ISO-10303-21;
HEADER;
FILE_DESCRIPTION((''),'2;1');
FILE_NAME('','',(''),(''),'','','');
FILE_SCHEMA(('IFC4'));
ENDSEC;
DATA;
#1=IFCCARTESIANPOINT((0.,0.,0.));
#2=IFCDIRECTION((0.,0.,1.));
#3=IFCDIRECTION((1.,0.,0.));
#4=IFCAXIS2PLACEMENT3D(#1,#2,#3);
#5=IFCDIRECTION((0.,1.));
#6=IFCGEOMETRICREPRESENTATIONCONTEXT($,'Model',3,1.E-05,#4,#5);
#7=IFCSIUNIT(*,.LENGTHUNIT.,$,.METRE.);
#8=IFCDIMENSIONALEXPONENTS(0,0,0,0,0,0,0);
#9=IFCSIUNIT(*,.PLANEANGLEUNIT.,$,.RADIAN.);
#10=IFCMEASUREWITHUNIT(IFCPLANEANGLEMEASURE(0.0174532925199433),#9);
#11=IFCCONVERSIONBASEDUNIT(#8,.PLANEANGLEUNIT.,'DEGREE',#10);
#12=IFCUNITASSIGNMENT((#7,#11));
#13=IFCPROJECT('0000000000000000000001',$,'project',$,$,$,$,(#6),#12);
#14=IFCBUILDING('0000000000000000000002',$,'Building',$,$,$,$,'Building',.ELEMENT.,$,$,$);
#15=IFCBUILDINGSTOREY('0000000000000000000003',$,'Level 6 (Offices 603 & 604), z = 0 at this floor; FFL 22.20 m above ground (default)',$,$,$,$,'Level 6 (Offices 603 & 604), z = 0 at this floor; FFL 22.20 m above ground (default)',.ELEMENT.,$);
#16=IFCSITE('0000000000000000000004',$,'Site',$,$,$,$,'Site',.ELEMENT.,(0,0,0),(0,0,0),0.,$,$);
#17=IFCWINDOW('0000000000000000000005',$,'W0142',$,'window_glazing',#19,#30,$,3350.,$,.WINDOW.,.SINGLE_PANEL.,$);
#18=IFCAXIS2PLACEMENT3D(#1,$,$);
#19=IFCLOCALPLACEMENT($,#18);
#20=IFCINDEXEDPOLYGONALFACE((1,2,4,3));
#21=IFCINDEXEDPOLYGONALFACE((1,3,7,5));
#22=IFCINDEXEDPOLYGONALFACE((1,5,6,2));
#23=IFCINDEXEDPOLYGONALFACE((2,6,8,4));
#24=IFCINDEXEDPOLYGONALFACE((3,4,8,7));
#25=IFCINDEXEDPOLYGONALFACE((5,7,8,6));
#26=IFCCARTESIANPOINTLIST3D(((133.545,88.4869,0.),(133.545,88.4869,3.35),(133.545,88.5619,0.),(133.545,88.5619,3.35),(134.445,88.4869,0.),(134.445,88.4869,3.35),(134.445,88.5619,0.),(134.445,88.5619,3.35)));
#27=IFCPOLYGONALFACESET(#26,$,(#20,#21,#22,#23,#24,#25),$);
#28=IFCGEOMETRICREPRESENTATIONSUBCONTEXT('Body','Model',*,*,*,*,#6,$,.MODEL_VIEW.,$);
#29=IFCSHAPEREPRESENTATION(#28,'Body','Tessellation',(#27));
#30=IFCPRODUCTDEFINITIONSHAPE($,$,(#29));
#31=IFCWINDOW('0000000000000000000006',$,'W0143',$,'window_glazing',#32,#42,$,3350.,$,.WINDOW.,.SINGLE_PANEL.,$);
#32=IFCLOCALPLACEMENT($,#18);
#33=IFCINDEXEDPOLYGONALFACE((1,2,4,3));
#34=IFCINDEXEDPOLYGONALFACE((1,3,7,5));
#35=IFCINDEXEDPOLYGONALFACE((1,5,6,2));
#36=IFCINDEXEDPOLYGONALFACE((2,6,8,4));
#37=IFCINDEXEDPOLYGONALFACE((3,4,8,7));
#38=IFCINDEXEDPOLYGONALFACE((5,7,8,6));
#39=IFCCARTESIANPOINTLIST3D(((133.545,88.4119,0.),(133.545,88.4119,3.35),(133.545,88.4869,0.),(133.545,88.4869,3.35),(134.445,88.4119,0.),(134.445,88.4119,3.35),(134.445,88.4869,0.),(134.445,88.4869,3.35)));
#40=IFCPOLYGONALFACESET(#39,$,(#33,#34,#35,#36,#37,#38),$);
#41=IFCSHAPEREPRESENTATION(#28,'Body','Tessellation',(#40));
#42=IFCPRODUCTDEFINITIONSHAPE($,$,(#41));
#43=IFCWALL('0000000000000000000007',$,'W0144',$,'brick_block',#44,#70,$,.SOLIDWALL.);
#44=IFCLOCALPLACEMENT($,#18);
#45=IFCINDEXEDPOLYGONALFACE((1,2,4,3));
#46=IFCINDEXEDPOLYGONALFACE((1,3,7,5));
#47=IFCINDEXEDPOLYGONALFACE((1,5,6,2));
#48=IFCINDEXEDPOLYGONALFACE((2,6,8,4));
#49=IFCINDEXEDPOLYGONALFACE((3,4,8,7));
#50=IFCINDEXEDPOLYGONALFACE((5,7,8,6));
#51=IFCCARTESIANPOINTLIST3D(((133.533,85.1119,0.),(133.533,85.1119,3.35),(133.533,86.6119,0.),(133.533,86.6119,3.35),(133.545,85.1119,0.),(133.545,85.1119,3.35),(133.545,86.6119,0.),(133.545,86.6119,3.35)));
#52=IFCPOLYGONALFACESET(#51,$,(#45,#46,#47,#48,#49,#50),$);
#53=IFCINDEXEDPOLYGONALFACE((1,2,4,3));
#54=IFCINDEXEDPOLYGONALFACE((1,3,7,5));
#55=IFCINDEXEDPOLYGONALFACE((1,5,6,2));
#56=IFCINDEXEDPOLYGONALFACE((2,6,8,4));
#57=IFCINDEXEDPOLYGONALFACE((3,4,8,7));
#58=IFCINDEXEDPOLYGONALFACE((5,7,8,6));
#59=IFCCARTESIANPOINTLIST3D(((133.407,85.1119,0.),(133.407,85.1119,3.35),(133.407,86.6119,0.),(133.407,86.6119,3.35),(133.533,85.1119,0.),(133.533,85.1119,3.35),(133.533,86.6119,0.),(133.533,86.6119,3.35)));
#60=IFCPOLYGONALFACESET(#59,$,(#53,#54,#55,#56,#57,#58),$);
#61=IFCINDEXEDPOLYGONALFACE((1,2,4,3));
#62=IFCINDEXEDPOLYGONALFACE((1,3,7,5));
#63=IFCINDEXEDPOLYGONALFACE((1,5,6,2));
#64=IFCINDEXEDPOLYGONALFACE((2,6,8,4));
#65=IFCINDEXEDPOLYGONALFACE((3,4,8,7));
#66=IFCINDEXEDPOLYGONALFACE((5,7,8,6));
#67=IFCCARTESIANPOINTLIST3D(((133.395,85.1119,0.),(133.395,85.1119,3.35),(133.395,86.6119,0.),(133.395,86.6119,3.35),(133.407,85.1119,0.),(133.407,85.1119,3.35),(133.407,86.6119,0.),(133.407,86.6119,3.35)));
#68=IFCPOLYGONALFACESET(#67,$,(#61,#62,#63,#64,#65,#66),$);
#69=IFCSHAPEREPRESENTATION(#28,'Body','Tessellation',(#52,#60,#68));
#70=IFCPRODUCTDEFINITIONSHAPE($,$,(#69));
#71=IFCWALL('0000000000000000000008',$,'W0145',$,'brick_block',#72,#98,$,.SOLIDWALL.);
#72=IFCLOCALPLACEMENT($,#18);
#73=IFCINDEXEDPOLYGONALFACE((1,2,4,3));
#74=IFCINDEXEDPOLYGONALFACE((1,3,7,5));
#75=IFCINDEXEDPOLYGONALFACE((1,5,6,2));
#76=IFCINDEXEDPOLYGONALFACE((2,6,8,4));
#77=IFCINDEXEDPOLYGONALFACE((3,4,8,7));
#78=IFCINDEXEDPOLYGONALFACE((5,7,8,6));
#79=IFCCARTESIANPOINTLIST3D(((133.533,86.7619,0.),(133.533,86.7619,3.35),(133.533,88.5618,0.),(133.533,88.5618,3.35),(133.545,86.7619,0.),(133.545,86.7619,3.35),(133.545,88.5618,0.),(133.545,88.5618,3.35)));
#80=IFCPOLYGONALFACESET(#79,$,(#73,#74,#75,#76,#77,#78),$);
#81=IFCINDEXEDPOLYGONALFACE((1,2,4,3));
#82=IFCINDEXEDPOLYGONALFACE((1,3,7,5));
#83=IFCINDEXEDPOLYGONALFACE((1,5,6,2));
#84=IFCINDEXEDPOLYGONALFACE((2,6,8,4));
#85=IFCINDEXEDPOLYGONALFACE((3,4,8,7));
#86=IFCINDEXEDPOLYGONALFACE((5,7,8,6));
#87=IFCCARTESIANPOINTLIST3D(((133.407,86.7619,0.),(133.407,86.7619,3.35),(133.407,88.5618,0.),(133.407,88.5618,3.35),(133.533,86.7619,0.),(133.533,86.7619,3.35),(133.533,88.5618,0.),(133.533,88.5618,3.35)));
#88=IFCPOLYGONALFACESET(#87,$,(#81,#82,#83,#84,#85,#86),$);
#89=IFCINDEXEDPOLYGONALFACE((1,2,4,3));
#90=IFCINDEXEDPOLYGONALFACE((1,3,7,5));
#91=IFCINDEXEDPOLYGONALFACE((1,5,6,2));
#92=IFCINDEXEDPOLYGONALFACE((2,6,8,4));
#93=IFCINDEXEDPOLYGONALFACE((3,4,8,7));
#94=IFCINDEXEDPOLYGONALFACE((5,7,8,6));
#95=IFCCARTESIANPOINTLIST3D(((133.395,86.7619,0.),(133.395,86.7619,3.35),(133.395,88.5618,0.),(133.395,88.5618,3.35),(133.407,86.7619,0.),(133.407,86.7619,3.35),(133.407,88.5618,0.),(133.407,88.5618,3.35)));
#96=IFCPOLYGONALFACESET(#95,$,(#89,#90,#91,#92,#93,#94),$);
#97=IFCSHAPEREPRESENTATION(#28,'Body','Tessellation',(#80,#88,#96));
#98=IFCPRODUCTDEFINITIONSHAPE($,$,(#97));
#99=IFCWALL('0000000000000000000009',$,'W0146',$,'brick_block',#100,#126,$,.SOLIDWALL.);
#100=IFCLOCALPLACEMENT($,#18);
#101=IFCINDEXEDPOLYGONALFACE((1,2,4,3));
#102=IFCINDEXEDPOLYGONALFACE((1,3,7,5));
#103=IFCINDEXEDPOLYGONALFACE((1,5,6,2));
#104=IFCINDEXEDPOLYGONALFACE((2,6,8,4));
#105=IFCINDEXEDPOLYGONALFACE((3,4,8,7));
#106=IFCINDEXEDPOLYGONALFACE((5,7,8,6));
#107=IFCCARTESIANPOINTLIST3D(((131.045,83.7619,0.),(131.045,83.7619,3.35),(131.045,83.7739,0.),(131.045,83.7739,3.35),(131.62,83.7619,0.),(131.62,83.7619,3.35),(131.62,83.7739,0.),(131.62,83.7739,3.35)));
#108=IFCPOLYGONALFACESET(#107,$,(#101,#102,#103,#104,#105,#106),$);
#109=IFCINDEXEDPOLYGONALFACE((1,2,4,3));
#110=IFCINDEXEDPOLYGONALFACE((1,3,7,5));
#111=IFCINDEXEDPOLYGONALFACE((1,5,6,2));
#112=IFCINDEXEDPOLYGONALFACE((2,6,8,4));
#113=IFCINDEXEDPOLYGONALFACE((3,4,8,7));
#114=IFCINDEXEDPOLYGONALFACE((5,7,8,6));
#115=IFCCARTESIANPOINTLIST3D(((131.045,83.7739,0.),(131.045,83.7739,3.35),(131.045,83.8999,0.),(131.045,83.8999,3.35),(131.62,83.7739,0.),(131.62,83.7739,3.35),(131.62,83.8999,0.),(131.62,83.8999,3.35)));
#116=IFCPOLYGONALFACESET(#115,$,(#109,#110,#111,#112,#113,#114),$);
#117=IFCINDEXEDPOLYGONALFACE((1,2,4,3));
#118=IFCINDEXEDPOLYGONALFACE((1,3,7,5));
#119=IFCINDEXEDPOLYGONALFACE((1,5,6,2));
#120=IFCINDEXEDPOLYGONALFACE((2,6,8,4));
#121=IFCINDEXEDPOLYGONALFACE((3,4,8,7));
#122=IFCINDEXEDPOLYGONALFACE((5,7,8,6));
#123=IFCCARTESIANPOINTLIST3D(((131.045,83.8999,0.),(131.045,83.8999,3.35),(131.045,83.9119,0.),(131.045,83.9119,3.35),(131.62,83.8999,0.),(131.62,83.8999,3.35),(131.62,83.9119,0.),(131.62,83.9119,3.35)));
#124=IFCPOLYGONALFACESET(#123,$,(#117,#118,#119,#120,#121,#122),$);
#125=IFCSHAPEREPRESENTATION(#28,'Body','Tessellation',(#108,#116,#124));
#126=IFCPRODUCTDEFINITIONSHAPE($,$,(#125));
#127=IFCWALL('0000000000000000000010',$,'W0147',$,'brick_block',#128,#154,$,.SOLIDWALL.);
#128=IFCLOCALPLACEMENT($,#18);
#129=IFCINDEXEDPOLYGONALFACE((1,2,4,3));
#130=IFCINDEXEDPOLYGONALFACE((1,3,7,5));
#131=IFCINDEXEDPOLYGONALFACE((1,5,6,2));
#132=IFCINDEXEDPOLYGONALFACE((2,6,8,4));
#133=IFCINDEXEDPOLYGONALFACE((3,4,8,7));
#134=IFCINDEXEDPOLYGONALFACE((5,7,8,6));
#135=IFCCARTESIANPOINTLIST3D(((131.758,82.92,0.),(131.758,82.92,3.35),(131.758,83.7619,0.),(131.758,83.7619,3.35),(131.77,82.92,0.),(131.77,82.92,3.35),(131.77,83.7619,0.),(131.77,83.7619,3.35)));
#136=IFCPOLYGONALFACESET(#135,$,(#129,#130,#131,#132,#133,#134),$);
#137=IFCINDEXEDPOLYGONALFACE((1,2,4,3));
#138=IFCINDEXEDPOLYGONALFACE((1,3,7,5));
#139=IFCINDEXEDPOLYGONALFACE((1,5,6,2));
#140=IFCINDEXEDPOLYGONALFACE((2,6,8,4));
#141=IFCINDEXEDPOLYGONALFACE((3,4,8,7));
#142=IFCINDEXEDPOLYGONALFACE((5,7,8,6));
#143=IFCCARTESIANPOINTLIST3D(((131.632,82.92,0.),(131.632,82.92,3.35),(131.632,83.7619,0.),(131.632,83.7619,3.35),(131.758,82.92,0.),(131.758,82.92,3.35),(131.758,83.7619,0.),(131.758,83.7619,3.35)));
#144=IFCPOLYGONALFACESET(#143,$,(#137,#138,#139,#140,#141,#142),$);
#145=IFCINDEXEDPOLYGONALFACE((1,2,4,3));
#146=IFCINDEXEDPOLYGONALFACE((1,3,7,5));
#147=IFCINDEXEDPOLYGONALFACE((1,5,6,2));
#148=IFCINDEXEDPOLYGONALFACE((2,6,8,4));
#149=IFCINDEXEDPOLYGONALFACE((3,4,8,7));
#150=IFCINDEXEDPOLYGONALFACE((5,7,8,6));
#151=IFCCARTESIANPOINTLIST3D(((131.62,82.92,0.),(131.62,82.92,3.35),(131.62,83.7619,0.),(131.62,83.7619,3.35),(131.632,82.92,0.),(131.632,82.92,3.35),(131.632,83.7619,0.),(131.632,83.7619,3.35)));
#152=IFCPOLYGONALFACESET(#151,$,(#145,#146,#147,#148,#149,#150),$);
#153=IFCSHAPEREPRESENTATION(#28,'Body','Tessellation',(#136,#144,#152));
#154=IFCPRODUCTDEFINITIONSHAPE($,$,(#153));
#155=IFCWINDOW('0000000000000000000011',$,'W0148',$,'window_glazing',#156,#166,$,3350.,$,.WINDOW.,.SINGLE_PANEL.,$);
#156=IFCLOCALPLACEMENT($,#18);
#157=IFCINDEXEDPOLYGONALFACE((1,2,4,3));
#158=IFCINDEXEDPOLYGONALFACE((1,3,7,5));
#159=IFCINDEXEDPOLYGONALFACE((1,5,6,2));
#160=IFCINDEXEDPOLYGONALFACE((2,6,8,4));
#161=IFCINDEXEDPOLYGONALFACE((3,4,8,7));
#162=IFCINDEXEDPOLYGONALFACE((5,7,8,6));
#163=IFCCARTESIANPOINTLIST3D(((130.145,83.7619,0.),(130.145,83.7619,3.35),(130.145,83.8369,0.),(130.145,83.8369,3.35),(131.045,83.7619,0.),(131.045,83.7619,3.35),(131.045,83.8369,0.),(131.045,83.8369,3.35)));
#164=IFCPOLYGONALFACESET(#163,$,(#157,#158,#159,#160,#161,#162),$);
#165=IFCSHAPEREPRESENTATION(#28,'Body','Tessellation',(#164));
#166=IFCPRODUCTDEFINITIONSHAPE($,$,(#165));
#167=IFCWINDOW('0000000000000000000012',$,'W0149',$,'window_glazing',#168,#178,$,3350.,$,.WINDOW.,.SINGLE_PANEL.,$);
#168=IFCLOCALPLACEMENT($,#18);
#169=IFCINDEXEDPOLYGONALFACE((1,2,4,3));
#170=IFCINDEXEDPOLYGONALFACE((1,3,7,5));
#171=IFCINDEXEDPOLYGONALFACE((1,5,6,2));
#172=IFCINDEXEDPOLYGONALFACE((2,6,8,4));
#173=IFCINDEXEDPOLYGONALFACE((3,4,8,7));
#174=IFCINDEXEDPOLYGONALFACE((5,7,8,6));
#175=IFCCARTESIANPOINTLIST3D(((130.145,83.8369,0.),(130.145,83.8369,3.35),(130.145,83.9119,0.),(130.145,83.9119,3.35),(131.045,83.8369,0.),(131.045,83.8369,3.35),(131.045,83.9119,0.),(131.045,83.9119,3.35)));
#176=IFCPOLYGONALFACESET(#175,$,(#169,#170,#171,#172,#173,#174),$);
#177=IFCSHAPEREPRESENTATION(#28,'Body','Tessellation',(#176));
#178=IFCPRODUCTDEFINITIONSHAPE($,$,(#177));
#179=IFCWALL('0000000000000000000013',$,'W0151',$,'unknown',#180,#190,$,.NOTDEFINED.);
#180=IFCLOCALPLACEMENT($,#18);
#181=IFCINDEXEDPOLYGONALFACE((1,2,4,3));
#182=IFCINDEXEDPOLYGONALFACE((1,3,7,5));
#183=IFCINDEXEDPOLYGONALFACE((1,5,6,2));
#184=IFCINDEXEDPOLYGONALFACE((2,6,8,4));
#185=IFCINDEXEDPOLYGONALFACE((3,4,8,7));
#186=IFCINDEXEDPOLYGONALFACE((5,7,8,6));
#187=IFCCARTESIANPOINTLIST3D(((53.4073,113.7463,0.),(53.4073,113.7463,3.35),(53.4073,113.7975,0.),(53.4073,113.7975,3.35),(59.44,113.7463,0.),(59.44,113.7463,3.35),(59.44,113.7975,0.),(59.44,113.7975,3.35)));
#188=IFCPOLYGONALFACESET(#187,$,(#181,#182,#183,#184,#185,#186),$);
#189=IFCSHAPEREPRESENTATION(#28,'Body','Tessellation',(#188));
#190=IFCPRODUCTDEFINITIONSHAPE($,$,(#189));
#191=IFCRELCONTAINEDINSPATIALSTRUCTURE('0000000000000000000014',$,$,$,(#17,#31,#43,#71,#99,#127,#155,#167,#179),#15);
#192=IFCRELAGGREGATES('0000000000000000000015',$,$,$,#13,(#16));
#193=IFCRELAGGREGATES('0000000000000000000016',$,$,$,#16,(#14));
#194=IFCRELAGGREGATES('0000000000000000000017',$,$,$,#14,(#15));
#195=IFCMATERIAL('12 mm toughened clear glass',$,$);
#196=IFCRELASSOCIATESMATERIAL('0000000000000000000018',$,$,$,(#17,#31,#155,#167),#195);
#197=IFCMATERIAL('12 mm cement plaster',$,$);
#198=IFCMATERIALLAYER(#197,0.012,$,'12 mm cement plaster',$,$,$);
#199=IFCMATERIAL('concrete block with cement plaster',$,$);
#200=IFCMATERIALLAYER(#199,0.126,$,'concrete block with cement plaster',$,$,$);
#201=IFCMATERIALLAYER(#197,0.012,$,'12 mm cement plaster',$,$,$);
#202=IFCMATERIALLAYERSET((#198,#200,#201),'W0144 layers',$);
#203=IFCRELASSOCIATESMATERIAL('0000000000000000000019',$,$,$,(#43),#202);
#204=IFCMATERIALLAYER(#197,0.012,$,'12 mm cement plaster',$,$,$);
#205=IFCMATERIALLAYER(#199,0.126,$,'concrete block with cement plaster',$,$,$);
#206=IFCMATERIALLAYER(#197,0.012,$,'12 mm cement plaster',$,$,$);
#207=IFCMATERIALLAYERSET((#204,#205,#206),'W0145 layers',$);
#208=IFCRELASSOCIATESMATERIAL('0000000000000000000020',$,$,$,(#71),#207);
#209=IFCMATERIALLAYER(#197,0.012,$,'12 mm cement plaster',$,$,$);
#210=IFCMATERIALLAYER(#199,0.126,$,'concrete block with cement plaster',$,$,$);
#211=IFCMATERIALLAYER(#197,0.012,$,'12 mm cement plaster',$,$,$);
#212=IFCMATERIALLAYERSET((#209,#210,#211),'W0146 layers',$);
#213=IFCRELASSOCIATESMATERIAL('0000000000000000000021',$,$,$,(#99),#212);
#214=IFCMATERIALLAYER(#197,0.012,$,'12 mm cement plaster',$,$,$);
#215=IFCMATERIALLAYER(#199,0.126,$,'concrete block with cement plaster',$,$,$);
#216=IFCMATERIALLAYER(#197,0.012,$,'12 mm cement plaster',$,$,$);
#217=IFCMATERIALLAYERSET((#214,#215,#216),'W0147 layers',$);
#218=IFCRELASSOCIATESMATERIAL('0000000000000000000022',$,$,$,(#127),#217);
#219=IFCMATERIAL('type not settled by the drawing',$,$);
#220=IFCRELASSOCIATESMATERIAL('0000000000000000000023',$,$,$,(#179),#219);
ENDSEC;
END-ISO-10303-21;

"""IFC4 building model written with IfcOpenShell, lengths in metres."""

from ifc_helpers import new_model, entity, si_unit, converted_unit, direction, frame, frame_2d, origin_with_axes, origin_2d_with_axis, place, context, subcontext, project, spatial, rectangle, extrude, material, layer, layer_set, layer_usage, element, save


model = new_model("IFC4")

# Units and contexts
model_context = context("Model", 3, precision=1e-05, world=origin_with_axes(), true_north=direction((0.0, 1.0)))
body_context = subcontext(model_context, "Body", "Model", "MODEL_VIEW")
ifc_project = project(units=[si_unit("LENGTHUNIT", "METRE"), converted_unit("PLANEANGLEUNIT", "DEGREE", entity("IfcPlaneAngleMeasure", 0.0174532925199433), si_unit("PLANEANGLEUNIT", "RADIAN"), dimensions=[0, 0, 0, 0, 0, 0, 0])], contexts=[model_context])

# Site, building, storey
site = spatial("IfcSite", under=ifc_project, Name="Site", LongName="Site", CompositionType="ELEMENT", RefLatitude=(0, 0, 0), RefLongitude=(0, 0, 0), RefElevation=0.0)
building = spatial("IfcBuilding", under=site, Name="Building", LongName="Building", CompositionType="ELEMENT")
storey = spatial("IfcBuildingStorey", under=building, Name="Level 6 (Offices 603 & 604), z = 0 at this floor; FFL 22.20 m above ground (default)", LongName="Level 6 (Offices 603 & 604), z = 0 at this floor; FFL 22.20 m above ground (default)", CompositionType="ELEMENT")

# Shared definitions
ifc_material_1 = material(Name="12 mm cement plaster")
ifc_material_2 = material(Name="concrete block with cement plaster")
placement = place(None, origin_with_axes())

# Windows
ifc_material_3 = material(Name="12 mm toughened clear glass")
element("IfcWindow", 1, at=placement, inside=storey, material=ifc_material_3, Name="W0142", ObjectType="window_glazing", OverallHeight=3350.0, PartitioningType="SINGLE_PANEL", PredefinedType="WINDOW", context=body_context, shape_type="SweptSolid", body=[
    extrude(rectangle(XDim=0.9, YDim=0.075, at=frame_2d((0.0, 0.0), x_axis=(1.0, 0.0))), frame((133.995, 88.5244, 0.0), z_axis=(0.0, 0.0, 1.0), x_axis=(1.0, 0.0, 0.0)), (0.0, 0.0, 1.0), 3.35),
])
element("IfcWindow", 2, at=placement, inside=storey, material=ifc_material_3, Name="W0143", ObjectType="window_glazing", OverallHeight=3350.0, PartitioningType="SINGLE_PANEL", PredefinedType="WINDOW", context=body_context, shape_type="SweptSolid", body=[
    extrude(rectangle(XDim=0.9, YDim=0.075, at=frame_2d((0.0, 0.0), x_axis=(1.0, 0.0))), frame((133.995, 88.4494, 0.0), z_axis=(0.0, 0.0, 1.0), x_axis=(1.0, 0.0, 0.0)), (0.0, 0.0, 1.0), 3.35),
])

# Walls
ifc_layer_1 = layer(ifc_material_1, 0.012, Name="12 mm cement plaster")
ifc_layer_2 = layer(ifc_material_2, 0.126, Name="concrete block with cement plaster")
ifc_layer_3 = layer(ifc_material_1, 0.012, Name="12 mm cement plaster")
ifc_layer_set_1 = layer_set([ifc_layer_1, ifc_layer_2, ifc_layer_3], Name="W0144 layers")
ifc_layer_usage_1 = layer_usage(ifc_layer_set_1, "AXIS2", "POSITIVE", -0.075)
element("IfcWall", 3, at=placement, inside=storey, material=ifc_layer_usage_1, Name="W0144", ObjectType="brick_block", PredefinedType="SOLIDWALL", context=body_context, shape_type="SweptSolid", body=[
    extrude(rectangle(XDim=1.5, YDim=0.012, at=frame_2d((0.0, 0.0), x_axis=(0.0, 1.0))), frame((133.539, 85.8619, 0.0), z_axis=(0.0, 0.0, 1.0), x_axis=(1.0, 0.0, 0.0)), (0.0, 0.0, 1.0), 3.35),
    extrude(rectangle(XDim=1.5, YDim=0.126, at=frame_2d((-0.069, 0.0), x_axis=(0.0, 1.0))), frame((133.539, 85.8619, 0.0), z_axis=(0.0, 0.0, 1.0), x_axis=(1.0, 0.0, 0.0)), (0.0, 0.0, 1.0), 3.35),
    extrude(rectangle(XDim=1.5, YDim=0.012, at=frame_2d((-0.138, 0.0), x_axis=(0.0, 1.0))), frame((133.539, 85.8619, 0.0), z_axis=(0.0, 0.0, 1.0), x_axis=(1.0, 0.0, 0.0)), (0.0, 0.0, 1.0), 3.35),
])
ifc_layer_4 = layer(ifc_material_1, 0.012, Name="12 mm cement plaster")
ifc_layer_5 = layer(ifc_material_2, 0.126, Name="concrete block with cement plaster")
ifc_layer_6 = layer(ifc_material_1, 0.012, Name="12 mm cement plaster")
ifc_layer_set_2 = layer_set([ifc_layer_4, ifc_layer_5, ifc_layer_6], Name="W0145 layers")
ifc_layer_usage_2 = layer_usage(ifc_layer_set_2, "AXIS2", "POSITIVE", -0.075)
element("IfcWall", 4, at=placement, inside=storey, material=ifc_layer_usage_2, Name="W0145", ObjectType="brick_block", PredefinedType="SOLIDWALL", context=body_context, shape_type="SweptSolid", body=[
    extrude(rectangle(XDim=1.7999, YDim=0.012, at=frame_2d((0.0, 0.0), x_axis=(0.0, 1.0))), frame((133.539, 87.6619, 0.0), z_axis=(0.0, 0.0, 1.0), x_axis=(1.0, 0.0, 0.0)), (0.0, 0.0, 1.0), 3.35),
    extrude(rectangle(XDim=1.7999, YDim=0.126, at=frame_2d((-0.069, 0.0), x_axis=(0.0, 1.0))), frame((133.539, 87.6619, 0.0), z_axis=(0.0, 0.0, 1.0), x_axis=(1.0, 0.0, 0.0)), (0.0, 0.0, 1.0), 3.35),
    extrude(rectangle(XDim=1.7999, YDim=0.012, at=frame_2d((-0.138, 0.0), x_axis=(0.0, 1.0))), frame((133.539, 87.6619, 0.0), z_axis=(0.0, 0.0, 1.0), x_axis=(1.0, 0.0, 0.0)), (0.0, 0.0, 1.0), 3.35),
])
ifc_layer_7 = layer(ifc_material_1, 0.012, Name="12 mm cement plaster")
ifc_layer_8 = layer(ifc_material_2, 0.126, Name="concrete block with cement plaster")
ifc_layer_9 = layer(ifc_material_1, 0.012, Name="12 mm cement plaster")
ifc_layer_set_3 = layer_set([ifc_layer_7, ifc_layer_8, ifc_layer_9], Name="W0146 layers")
ifc_layer_usage_3 = layer_usage(ifc_layer_set_3, "AXIS2", "POSITIVE", -0.075)
element("IfcWall", 5, at=placement, inside=storey, material=ifc_layer_usage_3, Name="W0146", ObjectType="brick_block", PredefinedType="SOLIDWALL", context=body_context, shape_type="SweptSolid", body=[
    extrude(rectangle(XDim=0.575, YDim=0.012, at=frame_2d((0.0, 0.0), x_axis=(1.0, 0.0))), frame((131.3325, 83.7679, 0.0), z_axis=(0.0, 0.0, 1.0), x_axis=(1.0, 0.0, 0.0)), (0.0, 0.0, 1.0), 3.35),
    extrude(rectangle(XDim=0.575, YDim=0.126, at=frame_2d((0.0, 0.069), x_axis=(1.0, 0.0))), frame((131.3325, 83.7679, 0.0), z_axis=(0.0, 0.0, 1.0), x_axis=(1.0, 0.0, 0.0)), (0.0, 0.0, 1.0), 3.35),
    extrude(rectangle(XDim=0.575, YDim=0.012, at=frame_2d((0.0, 0.138), x_axis=(1.0, 0.0))), frame((131.3325, 83.7679, 0.0), z_axis=(0.0, 0.0, 1.0), x_axis=(1.0, 0.0, 0.0)), (0.0, 0.0, 1.0), 3.35),
])
ifc_layer_10 = layer(ifc_material_1, 0.012, Name="12 mm cement plaster")
ifc_layer_11 = layer(ifc_material_2, 0.126, Name="concrete block with cement plaster")
ifc_layer_12 = layer(ifc_material_1, 0.012, Name="12 mm cement plaster")
ifc_layer_set_4 = layer_set([ifc_layer_10, ifc_layer_11, ifc_layer_12], Name="W0147 layers")
ifc_layer_usage_4 = layer_usage(ifc_layer_set_4, "AXIS2", "POSITIVE", -0.075)
element("IfcWall", 6, at=placement, inside=storey, material=ifc_layer_usage_4, Name="W0147", ObjectType="brick_block", PredefinedType="SOLIDWALL", context=body_context, shape_type="SweptSolid", body=[
    extrude(rectangle(XDim=0.8419, YDim=0.012, at=frame_2d((0.0, 0.0), x_axis=(0.0, 1.0))), frame((131.764, 83.341, 0.0), z_axis=(0.0, 0.0, 1.0), x_axis=(1.0, 0.0, 0.0)), (0.0, 0.0, 1.0), 3.35),
    extrude(rectangle(XDim=0.8419, YDim=0.126, at=frame_2d((-0.069, 0.0), x_axis=(0.0, 1.0))), frame((131.764, 83.341, 0.0), z_axis=(0.0, 0.0, 1.0), x_axis=(1.0, 0.0, 0.0)), (0.0, 0.0, 1.0), 3.35),
    extrude(rectangle(XDim=0.8419, YDim=0.012, at=frame_2d((-0.138, 0.0), x_axis=(0.0, 1.0))), frame((131.764, 83.341, 0.0), z_axis=(0.0, 0.0, 1.0), x_axis=(1.0, 0.0, 0.0)), (0.0, 0.0, 1.0), 3.35),
])

# Windows
element("IfcWindow", 7, at=placement, inside=storey, material=ifc_material_3, Name="W0148", ObjectType="window_glazing", OverallHeight=3350.0, PartitioningType="SINGLE_PANEL", PredefinedType="WINDOW", context=body_context, shape_type="SweptSolid", body=[
    extrude(rectangle(XDim=0.9, YDim=0.075, at=frame_2d((0.0, 0.0), x_axis=(1.0, 0.0))), frame((130.595, 83.7994, 0.0), z_axis=(0.0, 0.0, 1.0), x_axis=(1.0, 0.0, 0.0)), (0.0, 0.0, 1.0), 3.35),
])
element("IfcWindow", 8, at=placement, inside=storey, material=ifc_material_3, Name="W0149", ObjectType="window_glazing", OverallHeight=3350.0, PartitioningType="SINGLE_PANEL", PredefinedType="WINDOW", context=body_context, shape_type="SweptSolid", body=[
    extrude(rectangle(XDim=0.9, YDim=0.075, at=frame_2d((0.0, 0.0), x_axis=(1.0, 0.0))), frame((130.595, 83.8744, 0.0), z_axis=(0.0, 0.0, 1.0), x_axis=(1.0, 0.0, 0.0)), (0.0, 0.0, 1.0), 3.35),
])

# Wall
ifc_material_4 = material(Name="type not settled by the drawing")
element("IfcWall", 9, at=placement, inside=storey, material=ifc_material_4, Name="W0151", ObjectType="unknown", PredefinedType="NOTDEFINED", context=body_context, shape_type="SweptSolid", body=[
    extrude(rectangle(XDim=6.0327, YDim=0.0512, at=origin_2d_with_axis()), frame((56.4237, 113.7719, 0.0), z_axis=(0.0, 0.0, 1.0), x_axis=(1.0, 0.0, 0.0)), (0.0, 0.0, 1.0), 3.35),
])

save(model, "model.ifc")
